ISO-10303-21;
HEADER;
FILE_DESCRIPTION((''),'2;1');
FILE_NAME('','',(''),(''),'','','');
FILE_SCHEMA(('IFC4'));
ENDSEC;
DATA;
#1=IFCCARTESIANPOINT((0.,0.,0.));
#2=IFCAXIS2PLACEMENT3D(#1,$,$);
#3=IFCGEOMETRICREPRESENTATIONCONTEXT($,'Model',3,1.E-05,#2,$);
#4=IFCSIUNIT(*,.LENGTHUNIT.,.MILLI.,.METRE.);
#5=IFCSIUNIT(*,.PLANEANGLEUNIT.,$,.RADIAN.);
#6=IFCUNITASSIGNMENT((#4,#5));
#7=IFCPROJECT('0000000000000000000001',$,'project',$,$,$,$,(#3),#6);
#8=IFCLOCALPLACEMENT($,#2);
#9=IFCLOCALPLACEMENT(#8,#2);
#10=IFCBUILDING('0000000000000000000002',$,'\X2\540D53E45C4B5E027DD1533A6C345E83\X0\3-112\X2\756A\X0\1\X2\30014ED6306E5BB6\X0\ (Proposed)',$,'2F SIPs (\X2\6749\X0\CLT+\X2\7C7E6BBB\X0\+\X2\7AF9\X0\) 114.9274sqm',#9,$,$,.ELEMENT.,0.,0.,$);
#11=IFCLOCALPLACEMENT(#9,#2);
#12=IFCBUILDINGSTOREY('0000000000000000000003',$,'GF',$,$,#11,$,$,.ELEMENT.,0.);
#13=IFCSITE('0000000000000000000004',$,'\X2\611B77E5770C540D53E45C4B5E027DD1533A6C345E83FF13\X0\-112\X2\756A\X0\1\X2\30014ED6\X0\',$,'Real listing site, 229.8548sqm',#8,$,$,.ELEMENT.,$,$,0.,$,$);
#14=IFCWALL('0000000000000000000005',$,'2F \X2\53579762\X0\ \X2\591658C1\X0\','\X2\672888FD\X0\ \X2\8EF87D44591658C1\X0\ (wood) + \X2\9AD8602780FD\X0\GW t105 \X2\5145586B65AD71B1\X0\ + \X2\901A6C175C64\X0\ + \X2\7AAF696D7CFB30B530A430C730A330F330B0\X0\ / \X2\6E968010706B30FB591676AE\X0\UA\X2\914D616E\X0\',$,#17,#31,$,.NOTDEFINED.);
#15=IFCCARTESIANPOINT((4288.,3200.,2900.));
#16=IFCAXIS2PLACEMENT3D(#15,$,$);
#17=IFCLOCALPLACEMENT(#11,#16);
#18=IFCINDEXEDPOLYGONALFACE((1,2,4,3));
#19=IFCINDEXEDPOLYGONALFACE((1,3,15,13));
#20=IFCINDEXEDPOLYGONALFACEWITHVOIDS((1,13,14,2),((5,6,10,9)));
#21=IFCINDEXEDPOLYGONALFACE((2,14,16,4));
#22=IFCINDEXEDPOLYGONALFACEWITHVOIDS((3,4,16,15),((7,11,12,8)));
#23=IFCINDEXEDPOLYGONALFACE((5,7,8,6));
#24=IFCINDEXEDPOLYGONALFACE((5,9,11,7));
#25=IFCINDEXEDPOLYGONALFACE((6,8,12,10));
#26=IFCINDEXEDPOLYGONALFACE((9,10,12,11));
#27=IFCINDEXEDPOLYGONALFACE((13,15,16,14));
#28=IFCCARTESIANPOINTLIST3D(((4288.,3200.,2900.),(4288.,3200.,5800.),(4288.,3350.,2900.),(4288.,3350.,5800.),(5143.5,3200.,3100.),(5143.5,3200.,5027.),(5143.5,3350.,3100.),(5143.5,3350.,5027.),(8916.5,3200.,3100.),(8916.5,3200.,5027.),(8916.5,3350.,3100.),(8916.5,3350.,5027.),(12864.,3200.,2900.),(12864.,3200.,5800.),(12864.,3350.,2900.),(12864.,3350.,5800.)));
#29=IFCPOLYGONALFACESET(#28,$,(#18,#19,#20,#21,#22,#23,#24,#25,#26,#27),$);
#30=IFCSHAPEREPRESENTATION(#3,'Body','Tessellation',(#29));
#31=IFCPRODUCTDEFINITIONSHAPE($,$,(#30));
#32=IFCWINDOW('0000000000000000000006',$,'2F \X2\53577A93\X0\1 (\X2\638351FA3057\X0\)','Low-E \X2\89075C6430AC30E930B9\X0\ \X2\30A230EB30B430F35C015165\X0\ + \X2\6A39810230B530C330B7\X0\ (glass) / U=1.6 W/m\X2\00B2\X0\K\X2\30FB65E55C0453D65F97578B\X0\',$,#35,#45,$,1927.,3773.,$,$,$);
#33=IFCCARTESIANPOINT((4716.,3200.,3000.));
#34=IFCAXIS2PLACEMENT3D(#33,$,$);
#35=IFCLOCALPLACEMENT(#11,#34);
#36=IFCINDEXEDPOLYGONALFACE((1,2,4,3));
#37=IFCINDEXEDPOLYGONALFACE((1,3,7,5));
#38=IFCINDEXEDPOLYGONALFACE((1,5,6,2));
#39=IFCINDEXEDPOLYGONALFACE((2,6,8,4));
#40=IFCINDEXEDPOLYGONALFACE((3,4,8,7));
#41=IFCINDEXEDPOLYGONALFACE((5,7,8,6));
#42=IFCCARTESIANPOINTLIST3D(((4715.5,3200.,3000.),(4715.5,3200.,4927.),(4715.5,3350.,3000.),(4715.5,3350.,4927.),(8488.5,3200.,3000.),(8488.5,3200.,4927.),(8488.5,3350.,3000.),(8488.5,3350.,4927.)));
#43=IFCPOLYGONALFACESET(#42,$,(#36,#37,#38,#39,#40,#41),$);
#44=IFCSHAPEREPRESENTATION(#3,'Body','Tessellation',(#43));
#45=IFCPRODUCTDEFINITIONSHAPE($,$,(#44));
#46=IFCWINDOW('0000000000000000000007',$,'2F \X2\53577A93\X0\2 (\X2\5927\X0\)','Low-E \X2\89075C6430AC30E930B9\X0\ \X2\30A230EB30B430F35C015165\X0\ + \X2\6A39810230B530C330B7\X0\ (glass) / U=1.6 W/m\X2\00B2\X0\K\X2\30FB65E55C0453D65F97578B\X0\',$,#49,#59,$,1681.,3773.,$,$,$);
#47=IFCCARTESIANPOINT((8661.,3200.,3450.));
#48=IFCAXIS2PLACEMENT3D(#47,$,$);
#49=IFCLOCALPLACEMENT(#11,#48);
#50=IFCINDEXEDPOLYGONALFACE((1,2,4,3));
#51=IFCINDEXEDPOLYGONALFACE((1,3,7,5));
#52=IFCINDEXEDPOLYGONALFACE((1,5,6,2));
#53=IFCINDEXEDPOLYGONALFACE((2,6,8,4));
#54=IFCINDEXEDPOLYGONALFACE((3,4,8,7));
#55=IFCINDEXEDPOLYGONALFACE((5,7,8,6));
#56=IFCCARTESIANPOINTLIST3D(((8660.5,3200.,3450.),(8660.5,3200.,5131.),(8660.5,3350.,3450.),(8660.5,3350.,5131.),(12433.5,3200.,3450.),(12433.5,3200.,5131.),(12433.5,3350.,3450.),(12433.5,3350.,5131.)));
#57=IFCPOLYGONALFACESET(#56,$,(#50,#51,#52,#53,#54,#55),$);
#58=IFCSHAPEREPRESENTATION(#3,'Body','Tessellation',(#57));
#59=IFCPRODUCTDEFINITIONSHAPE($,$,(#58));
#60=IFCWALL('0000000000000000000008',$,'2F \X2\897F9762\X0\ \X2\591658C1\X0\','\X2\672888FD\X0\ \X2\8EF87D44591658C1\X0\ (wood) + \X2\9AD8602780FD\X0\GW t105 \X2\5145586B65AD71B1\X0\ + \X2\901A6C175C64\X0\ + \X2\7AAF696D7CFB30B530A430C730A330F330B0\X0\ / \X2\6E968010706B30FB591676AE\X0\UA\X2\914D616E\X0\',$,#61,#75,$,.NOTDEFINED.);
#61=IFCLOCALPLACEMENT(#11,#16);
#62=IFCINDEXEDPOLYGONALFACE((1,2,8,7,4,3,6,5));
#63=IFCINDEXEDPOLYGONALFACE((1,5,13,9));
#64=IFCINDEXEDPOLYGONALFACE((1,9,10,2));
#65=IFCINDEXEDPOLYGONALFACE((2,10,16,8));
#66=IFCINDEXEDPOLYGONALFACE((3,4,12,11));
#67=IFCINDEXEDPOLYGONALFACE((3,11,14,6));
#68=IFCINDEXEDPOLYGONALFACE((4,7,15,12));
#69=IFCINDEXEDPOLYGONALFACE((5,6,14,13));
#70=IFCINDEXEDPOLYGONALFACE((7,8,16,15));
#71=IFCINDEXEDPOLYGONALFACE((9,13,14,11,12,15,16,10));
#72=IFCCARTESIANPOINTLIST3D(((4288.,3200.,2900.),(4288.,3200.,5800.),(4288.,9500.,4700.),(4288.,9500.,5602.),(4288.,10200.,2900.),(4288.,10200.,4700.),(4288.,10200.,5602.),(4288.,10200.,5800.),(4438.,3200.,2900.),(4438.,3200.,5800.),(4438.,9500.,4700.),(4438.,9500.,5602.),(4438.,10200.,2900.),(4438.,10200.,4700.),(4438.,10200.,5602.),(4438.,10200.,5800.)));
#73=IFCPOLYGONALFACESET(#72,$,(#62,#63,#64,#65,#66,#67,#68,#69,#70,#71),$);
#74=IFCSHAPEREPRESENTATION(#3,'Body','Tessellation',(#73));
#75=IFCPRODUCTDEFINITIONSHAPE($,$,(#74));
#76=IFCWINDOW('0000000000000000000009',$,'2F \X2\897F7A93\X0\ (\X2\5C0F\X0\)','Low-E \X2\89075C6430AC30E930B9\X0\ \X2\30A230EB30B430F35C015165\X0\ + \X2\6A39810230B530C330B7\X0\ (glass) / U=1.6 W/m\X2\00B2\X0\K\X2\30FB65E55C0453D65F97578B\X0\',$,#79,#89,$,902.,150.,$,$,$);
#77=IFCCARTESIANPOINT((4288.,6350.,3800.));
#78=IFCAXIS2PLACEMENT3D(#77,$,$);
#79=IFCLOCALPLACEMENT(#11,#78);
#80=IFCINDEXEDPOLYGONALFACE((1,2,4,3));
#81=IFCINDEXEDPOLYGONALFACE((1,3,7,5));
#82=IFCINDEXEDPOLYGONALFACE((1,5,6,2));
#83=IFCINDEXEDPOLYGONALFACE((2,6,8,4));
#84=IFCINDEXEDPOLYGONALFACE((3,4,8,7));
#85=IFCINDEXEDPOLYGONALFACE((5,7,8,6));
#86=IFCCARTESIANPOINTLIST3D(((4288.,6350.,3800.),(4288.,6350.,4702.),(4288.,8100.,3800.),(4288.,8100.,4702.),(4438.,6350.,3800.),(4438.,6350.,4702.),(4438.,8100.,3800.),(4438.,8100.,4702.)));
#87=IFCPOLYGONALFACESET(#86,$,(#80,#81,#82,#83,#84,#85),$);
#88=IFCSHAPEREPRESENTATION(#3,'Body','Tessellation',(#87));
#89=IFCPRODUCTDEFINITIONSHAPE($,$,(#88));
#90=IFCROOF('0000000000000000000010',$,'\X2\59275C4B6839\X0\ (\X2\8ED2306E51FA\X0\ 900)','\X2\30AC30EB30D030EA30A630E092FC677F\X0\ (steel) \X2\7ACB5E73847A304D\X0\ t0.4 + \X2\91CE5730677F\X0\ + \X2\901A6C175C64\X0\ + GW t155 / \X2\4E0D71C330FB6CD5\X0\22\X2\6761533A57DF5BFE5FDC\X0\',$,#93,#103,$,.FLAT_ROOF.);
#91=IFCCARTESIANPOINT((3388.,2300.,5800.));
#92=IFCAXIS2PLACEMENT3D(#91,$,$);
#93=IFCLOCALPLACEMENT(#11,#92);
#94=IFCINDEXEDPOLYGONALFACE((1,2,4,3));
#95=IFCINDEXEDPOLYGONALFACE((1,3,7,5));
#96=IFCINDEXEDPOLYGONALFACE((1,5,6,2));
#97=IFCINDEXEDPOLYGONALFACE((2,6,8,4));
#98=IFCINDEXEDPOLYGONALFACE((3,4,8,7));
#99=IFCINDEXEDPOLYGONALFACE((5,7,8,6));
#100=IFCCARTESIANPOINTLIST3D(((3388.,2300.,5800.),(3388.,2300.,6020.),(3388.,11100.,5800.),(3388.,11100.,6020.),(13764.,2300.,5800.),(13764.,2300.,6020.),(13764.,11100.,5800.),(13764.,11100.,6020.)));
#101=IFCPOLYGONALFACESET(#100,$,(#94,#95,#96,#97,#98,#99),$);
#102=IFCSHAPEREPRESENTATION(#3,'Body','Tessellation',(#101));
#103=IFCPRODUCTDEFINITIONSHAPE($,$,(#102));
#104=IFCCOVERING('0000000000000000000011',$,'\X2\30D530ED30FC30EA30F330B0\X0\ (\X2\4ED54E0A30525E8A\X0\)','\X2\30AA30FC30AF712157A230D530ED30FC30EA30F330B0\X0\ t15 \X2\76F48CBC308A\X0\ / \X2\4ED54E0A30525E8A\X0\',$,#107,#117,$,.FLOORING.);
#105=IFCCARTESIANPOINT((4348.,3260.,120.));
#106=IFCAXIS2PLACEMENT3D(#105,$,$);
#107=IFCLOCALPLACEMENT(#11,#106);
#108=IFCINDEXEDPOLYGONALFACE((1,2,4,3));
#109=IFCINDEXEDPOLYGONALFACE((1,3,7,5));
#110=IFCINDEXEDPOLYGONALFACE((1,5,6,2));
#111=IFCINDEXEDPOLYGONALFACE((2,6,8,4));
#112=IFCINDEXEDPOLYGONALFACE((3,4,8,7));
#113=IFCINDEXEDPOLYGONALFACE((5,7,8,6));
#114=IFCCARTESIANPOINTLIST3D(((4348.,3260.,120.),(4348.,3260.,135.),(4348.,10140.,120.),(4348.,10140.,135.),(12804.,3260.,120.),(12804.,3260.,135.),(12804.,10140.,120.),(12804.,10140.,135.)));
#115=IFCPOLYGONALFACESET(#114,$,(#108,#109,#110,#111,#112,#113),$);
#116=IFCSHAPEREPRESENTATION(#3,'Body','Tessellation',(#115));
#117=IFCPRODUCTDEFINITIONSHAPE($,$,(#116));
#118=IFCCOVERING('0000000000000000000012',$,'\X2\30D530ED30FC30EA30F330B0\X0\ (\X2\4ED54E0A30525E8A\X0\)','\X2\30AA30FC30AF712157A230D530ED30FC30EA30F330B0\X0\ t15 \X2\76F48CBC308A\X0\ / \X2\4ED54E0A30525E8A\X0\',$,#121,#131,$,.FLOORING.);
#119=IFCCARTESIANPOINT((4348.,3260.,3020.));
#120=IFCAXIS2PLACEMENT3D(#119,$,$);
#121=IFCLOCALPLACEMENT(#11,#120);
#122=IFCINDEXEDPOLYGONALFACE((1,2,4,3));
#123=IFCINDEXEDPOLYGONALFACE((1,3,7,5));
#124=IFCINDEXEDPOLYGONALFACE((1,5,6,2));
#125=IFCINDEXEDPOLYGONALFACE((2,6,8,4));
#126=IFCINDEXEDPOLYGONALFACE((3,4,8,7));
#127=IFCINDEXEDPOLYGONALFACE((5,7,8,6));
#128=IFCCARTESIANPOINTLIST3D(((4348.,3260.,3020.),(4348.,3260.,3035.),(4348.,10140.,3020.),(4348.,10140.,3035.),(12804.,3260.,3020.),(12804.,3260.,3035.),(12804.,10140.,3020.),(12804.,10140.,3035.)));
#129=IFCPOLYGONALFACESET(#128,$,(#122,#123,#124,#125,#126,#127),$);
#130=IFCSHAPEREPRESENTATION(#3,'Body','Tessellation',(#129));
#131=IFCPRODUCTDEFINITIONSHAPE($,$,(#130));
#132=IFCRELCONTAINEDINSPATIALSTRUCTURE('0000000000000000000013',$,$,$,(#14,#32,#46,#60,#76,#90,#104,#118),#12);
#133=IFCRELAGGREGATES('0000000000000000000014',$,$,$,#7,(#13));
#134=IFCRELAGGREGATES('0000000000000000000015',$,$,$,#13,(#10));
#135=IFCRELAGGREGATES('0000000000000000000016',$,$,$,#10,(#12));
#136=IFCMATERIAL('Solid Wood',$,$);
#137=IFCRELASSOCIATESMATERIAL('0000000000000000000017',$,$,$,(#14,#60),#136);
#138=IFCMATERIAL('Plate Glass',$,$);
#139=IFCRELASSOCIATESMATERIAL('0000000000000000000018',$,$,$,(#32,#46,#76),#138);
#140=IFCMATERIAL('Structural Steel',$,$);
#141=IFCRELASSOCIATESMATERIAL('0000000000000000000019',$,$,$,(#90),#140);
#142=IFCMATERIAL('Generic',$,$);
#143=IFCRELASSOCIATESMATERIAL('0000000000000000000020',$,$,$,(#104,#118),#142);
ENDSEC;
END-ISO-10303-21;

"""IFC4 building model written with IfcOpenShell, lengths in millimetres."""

from ifc_helpers import new_model, si_unit, frame, frame_2d, origin, place, context, project, spatial, rectangle, extrude, material, element, fill, save


model = new_model("IFC4")

# Units and contexts
model_context = context("Model", 3, precision=1e-05, world=origin())
ifc_project = project(units=[si_unit("LENGTHUNIT", "METRE", prefix="MILLI"), si_unit("PLANEANGLEUNIT", "RADIAN")], contexts=[model_context])

# Site, building, storey
site_placement = place(None, origin())
site = spatial("IfcSite", under=ifc_project, at=site_placement, Name="愛知県名古屋市緑区水広３-112番1、他", ObjectType="Real listing site, 229.8548sqm", CompositionType="ELEMENT", RefElevation=0.0)
building_placement = place(site_placement, origin())
building = spatial("IfcBuilding", under=site, at=building_placement, Name="名古屋市緑区水広3-112番1、他の家 (Proposed)", ObjectType="2F SIPs (杉CLT+籾殻+竹) 114.9274sqm", CompositionType="ELEMENT", ElevationOfRefHeight=0.0, ElevationOfTerrain=0.0)
storey_placement = place(building_placement, origin())
storey = spatial("IfcBuildingStorey", under=building, at=storey_placement, Name="GF", CompositionType="ELEMENT", Elevation=0.0)

# Shared definitions
ifc_material_1 = material(Name="Solid Wood")

# Shared definitions
ifc_material_2 = material(Name="Plate Glass")

# Wall, openings, windows
wall_1_placement = place(storey_placement, frame((4288.0, 3200.0, 2900.0)))
wall_1 = element("IfcWall", 1, at=wall_1_placement, inside=storey, material=ifc_material_1, Name="2F 南面 外壁", Description="木製 軸組外壁 (wood) + 高性能GW t105 充填断熱 + 通気層 + 窯業系サイディング / 準耐火・外皮UA配慮", PredefinedType="NOTDEFINED", context=model_context, shape_type="SweptSolid", body=[
    extrude(rectangle(XDim=8576.0, YDim=150.0, at=frame_2d((4288.0, 75.0))), frame((4288.0, 3200.0, 2900.0)), (0.0, 0.0, 1.0), 2900.0),
])
opening_1_placement = place(storey_placement, frame((4716.0, 3200.0, 3000.0)))
opening_1 = element("IfcOpeningElement", 2, at=opening_1_placement, cuts=wall_1, PredefinedType="NOTDEFINED", context=model_context, shape_type="SweptSolid", body=[
    extrude(rectangle(XDim=3773.0, YDim=150.0, at=frame_2d((1886.0, 75.0))), frame((4716.0, 3200.0, 3000.0)), (0.0, 0.0, 1.0), 1927.0),
])
opening_2_placement = place(storey_placement, frame((8661.0, 3200.0, 3450.0)))
opening_2 = element("IfcOpeningElement", 3, at=opening_2_placement, cuts=wall_1, PredefinedType="NOTDEFINED", context=model_context, shape_type="SweptSolid", body=[
    extrude(rectangle(XDim=3773.0, YDim=150.0, at=frame_2d((1886.0, 75.0))), frame((8661.0, 3200.0, 3450.0)), (0.0, 0.0, 1.0), 1681.0),
])
window_1_placement = place(storey_placement, frame((4716.0, 3200.0, 3000.0)))
window_1 = element("IfcWindow", 4, at=window_1_placement, inside=storey, material=ifc_material_2, Name="2F 南窓1 (掃出し)", Description="Low-E 複層ガラス アルゴン封入 + 樹脂サッシ (glass) / U=1.6 W/m²K・日射取得型", OverallHeight=1927.0, OverallWidth=3773.0, context=model_context, shape_type="SweptSolid", body=[
    extrude(rectangle(XDim=3773.0, YDim=150.0, at=frame_2d((1886.0, 75.0))), frame((4716.0, 3200.0, 3000.0)), (0.0, 0.0, 1.0), 1927.0),
])
fill(opening_1, window_1)
window_2_placement = place(storey_placement, frame((8661.0, 3200.0, 3450.0)))
window_2 = element("IfcWindow", 5, at=window_2_placement, inside=storey, material=ifc_material_2, Name="2F 南窓2 (大)", Description="Low-E 複層ガラス アルゴン封入 + 樹脂サッシ (glass) / U=1.6 W/m²K・日射取得型", OverallHeight=1681.0, OverallWidth=3773.0, context=model_context, shape_type="SweptSolid", body=[
    extrude(rectangle(XDim=3773.0, YDim=150.0, at=frame_2d((1886.0, 75.0))), frame((8661.0, 3200.0, 3450.0)), (0.0, 0.0, 1.0), 1681.0),
])
fill(opening_2, window_2)

# Wall, opening, window
wall_2_placement = place(storey_placement, frame((4288.0, 3200.0, 2900.0)))
wall_2 = element("IfcWall", 6, at=wall_2_placement, inside=storey, material=ifc_material_1, Name="2F 西面 外壁", Description="木製 軸組外壁 (wood) + 高性能GW t105 充填断熱 + 通気層 + 窯業系サイディング / 準耐火・外皮UA配慮", PredefinedType="NOTDEFINED", context=model_context, shape_type="SweptSolid", body=[
    extrude(rectangle(XDim=150.0, YDim=7000.0, at=frame_2d((75.0, 3500.0))), frame((4288.0, 3200.0, 2900.0)), (0.0, 0.0, 1.0), 2900.0),
])
opening_3_placement = place(storey_placement, frame((4288.0, 6350.0, 3800.0)))
opening_3 = element("IfcOpeningElement", 7, at=opening_3_placement, cuts=wall_2, PredefinedType="NOTDEFINED", context=model_context, shape_type="SweptSolid", body=[
    extrude(rectangle(XDim=150.0, YDim=1750.0, at=frame_2d((75.0, 875.0))), frame((4288.0, 6350.0, 3800.0)), (0.0, 0.0, 1.0), 902.0),
])
window_3_placement = place(storey_placement, frame((4288.0, 6350.0, 3800.0)))
window_3 = element("IfcWindow", 8, at=window_3_placement, inside=storey, material=ifc_material_2, Name="2F 西窓 (小)", Description="Low-E 複層ガラス アルゴン封入 + 樹脂サッシ (glass) / U=1.6 W/m²K・日射取得型", OverallHeight=902.0, OverallWidth=150.0, context=model_context, shape_type="SweptSolid", body=[
    extrude(rectangle(XDim=150.0, YDim=1750.0, at=frame_2d((75.0, 875.0))), frame((4288.0, 6350.0, 3800.0)), (0.0, 0.0, 1.0), 902.0),
])
fill(opening_3, window_3)

# Roof
ifc_material_3 = material(Name="Structural Steel")
roof_placement = place(storey_placement, frame((3388.0, 2300.0, 5800.0)))
element("IfcRoof", 9, at=roof_placement, inside=storey, material=ifc_material_3, Name="大屋根 (軒の出 900)", Description="ガルバリウム鋼板 (steel) 立平葺き t0.4 + 野地板 + 通気層 + GW t155 / 不燃・法22条区域対応", PredefinedType="FLAT_ROOF", context=model_context, shape_type="SweptSolid", body=[
    extrude(rectangle(XDim=10376.0, YDim=8800.0, at=frame_2d((5188.0, 4400.0))), frame((3388.0, 2300.0, 5800.0)), (0.0, 0.0, 1.0), 220.0),
])

# Coverings
ifc_material_4 = material(Name="Generic")
covering_1_placement = place(storey_placement, frame((4348.0, 3260.0, 120.0)))
element("IfcCovering", 10, at=covering_1_placement, inside=storey, material=ifc_material_4, Name="フローリング (仕上げ床)", Description="オーク無垢フローリング t15 直貼り / 仕上げ床", PredefinedType="FLOORING", context=model_context, shape_type="SweptSolid", body=[
    extrude(rectangle(XDim=8456.0, YDim=6880.0, at=frame_2d((4228.0, 3440.0))), frame((4348.0, 3260.0, 120.0)), (0.0, 0.0, 1.0), 15.0),
])
covering_2_placement = place(storey_placement, frame((4348.0, 3260.0, 3020.0)))
element("IfcCovering", 11, at=covering_2_placement, inside=storey, material=ifc_material_4, Name="フローリング (仕上げ床)", Description="オーク無垢フローリング t15 直貼り / 仕上げ床", PredefinedType="FLOORING", context=model_context, shape_type="SweptSolid", body=[
    extrude(rectangle(XDim=8456.0, YDim=6880.0, at=frame_2d((4228.0, 3440.0))), frame((4348.0, 3260.0, 3020.0)), (0.0, 0.0, 1.0), 15.0),
])

save(model, "model.ifc")
